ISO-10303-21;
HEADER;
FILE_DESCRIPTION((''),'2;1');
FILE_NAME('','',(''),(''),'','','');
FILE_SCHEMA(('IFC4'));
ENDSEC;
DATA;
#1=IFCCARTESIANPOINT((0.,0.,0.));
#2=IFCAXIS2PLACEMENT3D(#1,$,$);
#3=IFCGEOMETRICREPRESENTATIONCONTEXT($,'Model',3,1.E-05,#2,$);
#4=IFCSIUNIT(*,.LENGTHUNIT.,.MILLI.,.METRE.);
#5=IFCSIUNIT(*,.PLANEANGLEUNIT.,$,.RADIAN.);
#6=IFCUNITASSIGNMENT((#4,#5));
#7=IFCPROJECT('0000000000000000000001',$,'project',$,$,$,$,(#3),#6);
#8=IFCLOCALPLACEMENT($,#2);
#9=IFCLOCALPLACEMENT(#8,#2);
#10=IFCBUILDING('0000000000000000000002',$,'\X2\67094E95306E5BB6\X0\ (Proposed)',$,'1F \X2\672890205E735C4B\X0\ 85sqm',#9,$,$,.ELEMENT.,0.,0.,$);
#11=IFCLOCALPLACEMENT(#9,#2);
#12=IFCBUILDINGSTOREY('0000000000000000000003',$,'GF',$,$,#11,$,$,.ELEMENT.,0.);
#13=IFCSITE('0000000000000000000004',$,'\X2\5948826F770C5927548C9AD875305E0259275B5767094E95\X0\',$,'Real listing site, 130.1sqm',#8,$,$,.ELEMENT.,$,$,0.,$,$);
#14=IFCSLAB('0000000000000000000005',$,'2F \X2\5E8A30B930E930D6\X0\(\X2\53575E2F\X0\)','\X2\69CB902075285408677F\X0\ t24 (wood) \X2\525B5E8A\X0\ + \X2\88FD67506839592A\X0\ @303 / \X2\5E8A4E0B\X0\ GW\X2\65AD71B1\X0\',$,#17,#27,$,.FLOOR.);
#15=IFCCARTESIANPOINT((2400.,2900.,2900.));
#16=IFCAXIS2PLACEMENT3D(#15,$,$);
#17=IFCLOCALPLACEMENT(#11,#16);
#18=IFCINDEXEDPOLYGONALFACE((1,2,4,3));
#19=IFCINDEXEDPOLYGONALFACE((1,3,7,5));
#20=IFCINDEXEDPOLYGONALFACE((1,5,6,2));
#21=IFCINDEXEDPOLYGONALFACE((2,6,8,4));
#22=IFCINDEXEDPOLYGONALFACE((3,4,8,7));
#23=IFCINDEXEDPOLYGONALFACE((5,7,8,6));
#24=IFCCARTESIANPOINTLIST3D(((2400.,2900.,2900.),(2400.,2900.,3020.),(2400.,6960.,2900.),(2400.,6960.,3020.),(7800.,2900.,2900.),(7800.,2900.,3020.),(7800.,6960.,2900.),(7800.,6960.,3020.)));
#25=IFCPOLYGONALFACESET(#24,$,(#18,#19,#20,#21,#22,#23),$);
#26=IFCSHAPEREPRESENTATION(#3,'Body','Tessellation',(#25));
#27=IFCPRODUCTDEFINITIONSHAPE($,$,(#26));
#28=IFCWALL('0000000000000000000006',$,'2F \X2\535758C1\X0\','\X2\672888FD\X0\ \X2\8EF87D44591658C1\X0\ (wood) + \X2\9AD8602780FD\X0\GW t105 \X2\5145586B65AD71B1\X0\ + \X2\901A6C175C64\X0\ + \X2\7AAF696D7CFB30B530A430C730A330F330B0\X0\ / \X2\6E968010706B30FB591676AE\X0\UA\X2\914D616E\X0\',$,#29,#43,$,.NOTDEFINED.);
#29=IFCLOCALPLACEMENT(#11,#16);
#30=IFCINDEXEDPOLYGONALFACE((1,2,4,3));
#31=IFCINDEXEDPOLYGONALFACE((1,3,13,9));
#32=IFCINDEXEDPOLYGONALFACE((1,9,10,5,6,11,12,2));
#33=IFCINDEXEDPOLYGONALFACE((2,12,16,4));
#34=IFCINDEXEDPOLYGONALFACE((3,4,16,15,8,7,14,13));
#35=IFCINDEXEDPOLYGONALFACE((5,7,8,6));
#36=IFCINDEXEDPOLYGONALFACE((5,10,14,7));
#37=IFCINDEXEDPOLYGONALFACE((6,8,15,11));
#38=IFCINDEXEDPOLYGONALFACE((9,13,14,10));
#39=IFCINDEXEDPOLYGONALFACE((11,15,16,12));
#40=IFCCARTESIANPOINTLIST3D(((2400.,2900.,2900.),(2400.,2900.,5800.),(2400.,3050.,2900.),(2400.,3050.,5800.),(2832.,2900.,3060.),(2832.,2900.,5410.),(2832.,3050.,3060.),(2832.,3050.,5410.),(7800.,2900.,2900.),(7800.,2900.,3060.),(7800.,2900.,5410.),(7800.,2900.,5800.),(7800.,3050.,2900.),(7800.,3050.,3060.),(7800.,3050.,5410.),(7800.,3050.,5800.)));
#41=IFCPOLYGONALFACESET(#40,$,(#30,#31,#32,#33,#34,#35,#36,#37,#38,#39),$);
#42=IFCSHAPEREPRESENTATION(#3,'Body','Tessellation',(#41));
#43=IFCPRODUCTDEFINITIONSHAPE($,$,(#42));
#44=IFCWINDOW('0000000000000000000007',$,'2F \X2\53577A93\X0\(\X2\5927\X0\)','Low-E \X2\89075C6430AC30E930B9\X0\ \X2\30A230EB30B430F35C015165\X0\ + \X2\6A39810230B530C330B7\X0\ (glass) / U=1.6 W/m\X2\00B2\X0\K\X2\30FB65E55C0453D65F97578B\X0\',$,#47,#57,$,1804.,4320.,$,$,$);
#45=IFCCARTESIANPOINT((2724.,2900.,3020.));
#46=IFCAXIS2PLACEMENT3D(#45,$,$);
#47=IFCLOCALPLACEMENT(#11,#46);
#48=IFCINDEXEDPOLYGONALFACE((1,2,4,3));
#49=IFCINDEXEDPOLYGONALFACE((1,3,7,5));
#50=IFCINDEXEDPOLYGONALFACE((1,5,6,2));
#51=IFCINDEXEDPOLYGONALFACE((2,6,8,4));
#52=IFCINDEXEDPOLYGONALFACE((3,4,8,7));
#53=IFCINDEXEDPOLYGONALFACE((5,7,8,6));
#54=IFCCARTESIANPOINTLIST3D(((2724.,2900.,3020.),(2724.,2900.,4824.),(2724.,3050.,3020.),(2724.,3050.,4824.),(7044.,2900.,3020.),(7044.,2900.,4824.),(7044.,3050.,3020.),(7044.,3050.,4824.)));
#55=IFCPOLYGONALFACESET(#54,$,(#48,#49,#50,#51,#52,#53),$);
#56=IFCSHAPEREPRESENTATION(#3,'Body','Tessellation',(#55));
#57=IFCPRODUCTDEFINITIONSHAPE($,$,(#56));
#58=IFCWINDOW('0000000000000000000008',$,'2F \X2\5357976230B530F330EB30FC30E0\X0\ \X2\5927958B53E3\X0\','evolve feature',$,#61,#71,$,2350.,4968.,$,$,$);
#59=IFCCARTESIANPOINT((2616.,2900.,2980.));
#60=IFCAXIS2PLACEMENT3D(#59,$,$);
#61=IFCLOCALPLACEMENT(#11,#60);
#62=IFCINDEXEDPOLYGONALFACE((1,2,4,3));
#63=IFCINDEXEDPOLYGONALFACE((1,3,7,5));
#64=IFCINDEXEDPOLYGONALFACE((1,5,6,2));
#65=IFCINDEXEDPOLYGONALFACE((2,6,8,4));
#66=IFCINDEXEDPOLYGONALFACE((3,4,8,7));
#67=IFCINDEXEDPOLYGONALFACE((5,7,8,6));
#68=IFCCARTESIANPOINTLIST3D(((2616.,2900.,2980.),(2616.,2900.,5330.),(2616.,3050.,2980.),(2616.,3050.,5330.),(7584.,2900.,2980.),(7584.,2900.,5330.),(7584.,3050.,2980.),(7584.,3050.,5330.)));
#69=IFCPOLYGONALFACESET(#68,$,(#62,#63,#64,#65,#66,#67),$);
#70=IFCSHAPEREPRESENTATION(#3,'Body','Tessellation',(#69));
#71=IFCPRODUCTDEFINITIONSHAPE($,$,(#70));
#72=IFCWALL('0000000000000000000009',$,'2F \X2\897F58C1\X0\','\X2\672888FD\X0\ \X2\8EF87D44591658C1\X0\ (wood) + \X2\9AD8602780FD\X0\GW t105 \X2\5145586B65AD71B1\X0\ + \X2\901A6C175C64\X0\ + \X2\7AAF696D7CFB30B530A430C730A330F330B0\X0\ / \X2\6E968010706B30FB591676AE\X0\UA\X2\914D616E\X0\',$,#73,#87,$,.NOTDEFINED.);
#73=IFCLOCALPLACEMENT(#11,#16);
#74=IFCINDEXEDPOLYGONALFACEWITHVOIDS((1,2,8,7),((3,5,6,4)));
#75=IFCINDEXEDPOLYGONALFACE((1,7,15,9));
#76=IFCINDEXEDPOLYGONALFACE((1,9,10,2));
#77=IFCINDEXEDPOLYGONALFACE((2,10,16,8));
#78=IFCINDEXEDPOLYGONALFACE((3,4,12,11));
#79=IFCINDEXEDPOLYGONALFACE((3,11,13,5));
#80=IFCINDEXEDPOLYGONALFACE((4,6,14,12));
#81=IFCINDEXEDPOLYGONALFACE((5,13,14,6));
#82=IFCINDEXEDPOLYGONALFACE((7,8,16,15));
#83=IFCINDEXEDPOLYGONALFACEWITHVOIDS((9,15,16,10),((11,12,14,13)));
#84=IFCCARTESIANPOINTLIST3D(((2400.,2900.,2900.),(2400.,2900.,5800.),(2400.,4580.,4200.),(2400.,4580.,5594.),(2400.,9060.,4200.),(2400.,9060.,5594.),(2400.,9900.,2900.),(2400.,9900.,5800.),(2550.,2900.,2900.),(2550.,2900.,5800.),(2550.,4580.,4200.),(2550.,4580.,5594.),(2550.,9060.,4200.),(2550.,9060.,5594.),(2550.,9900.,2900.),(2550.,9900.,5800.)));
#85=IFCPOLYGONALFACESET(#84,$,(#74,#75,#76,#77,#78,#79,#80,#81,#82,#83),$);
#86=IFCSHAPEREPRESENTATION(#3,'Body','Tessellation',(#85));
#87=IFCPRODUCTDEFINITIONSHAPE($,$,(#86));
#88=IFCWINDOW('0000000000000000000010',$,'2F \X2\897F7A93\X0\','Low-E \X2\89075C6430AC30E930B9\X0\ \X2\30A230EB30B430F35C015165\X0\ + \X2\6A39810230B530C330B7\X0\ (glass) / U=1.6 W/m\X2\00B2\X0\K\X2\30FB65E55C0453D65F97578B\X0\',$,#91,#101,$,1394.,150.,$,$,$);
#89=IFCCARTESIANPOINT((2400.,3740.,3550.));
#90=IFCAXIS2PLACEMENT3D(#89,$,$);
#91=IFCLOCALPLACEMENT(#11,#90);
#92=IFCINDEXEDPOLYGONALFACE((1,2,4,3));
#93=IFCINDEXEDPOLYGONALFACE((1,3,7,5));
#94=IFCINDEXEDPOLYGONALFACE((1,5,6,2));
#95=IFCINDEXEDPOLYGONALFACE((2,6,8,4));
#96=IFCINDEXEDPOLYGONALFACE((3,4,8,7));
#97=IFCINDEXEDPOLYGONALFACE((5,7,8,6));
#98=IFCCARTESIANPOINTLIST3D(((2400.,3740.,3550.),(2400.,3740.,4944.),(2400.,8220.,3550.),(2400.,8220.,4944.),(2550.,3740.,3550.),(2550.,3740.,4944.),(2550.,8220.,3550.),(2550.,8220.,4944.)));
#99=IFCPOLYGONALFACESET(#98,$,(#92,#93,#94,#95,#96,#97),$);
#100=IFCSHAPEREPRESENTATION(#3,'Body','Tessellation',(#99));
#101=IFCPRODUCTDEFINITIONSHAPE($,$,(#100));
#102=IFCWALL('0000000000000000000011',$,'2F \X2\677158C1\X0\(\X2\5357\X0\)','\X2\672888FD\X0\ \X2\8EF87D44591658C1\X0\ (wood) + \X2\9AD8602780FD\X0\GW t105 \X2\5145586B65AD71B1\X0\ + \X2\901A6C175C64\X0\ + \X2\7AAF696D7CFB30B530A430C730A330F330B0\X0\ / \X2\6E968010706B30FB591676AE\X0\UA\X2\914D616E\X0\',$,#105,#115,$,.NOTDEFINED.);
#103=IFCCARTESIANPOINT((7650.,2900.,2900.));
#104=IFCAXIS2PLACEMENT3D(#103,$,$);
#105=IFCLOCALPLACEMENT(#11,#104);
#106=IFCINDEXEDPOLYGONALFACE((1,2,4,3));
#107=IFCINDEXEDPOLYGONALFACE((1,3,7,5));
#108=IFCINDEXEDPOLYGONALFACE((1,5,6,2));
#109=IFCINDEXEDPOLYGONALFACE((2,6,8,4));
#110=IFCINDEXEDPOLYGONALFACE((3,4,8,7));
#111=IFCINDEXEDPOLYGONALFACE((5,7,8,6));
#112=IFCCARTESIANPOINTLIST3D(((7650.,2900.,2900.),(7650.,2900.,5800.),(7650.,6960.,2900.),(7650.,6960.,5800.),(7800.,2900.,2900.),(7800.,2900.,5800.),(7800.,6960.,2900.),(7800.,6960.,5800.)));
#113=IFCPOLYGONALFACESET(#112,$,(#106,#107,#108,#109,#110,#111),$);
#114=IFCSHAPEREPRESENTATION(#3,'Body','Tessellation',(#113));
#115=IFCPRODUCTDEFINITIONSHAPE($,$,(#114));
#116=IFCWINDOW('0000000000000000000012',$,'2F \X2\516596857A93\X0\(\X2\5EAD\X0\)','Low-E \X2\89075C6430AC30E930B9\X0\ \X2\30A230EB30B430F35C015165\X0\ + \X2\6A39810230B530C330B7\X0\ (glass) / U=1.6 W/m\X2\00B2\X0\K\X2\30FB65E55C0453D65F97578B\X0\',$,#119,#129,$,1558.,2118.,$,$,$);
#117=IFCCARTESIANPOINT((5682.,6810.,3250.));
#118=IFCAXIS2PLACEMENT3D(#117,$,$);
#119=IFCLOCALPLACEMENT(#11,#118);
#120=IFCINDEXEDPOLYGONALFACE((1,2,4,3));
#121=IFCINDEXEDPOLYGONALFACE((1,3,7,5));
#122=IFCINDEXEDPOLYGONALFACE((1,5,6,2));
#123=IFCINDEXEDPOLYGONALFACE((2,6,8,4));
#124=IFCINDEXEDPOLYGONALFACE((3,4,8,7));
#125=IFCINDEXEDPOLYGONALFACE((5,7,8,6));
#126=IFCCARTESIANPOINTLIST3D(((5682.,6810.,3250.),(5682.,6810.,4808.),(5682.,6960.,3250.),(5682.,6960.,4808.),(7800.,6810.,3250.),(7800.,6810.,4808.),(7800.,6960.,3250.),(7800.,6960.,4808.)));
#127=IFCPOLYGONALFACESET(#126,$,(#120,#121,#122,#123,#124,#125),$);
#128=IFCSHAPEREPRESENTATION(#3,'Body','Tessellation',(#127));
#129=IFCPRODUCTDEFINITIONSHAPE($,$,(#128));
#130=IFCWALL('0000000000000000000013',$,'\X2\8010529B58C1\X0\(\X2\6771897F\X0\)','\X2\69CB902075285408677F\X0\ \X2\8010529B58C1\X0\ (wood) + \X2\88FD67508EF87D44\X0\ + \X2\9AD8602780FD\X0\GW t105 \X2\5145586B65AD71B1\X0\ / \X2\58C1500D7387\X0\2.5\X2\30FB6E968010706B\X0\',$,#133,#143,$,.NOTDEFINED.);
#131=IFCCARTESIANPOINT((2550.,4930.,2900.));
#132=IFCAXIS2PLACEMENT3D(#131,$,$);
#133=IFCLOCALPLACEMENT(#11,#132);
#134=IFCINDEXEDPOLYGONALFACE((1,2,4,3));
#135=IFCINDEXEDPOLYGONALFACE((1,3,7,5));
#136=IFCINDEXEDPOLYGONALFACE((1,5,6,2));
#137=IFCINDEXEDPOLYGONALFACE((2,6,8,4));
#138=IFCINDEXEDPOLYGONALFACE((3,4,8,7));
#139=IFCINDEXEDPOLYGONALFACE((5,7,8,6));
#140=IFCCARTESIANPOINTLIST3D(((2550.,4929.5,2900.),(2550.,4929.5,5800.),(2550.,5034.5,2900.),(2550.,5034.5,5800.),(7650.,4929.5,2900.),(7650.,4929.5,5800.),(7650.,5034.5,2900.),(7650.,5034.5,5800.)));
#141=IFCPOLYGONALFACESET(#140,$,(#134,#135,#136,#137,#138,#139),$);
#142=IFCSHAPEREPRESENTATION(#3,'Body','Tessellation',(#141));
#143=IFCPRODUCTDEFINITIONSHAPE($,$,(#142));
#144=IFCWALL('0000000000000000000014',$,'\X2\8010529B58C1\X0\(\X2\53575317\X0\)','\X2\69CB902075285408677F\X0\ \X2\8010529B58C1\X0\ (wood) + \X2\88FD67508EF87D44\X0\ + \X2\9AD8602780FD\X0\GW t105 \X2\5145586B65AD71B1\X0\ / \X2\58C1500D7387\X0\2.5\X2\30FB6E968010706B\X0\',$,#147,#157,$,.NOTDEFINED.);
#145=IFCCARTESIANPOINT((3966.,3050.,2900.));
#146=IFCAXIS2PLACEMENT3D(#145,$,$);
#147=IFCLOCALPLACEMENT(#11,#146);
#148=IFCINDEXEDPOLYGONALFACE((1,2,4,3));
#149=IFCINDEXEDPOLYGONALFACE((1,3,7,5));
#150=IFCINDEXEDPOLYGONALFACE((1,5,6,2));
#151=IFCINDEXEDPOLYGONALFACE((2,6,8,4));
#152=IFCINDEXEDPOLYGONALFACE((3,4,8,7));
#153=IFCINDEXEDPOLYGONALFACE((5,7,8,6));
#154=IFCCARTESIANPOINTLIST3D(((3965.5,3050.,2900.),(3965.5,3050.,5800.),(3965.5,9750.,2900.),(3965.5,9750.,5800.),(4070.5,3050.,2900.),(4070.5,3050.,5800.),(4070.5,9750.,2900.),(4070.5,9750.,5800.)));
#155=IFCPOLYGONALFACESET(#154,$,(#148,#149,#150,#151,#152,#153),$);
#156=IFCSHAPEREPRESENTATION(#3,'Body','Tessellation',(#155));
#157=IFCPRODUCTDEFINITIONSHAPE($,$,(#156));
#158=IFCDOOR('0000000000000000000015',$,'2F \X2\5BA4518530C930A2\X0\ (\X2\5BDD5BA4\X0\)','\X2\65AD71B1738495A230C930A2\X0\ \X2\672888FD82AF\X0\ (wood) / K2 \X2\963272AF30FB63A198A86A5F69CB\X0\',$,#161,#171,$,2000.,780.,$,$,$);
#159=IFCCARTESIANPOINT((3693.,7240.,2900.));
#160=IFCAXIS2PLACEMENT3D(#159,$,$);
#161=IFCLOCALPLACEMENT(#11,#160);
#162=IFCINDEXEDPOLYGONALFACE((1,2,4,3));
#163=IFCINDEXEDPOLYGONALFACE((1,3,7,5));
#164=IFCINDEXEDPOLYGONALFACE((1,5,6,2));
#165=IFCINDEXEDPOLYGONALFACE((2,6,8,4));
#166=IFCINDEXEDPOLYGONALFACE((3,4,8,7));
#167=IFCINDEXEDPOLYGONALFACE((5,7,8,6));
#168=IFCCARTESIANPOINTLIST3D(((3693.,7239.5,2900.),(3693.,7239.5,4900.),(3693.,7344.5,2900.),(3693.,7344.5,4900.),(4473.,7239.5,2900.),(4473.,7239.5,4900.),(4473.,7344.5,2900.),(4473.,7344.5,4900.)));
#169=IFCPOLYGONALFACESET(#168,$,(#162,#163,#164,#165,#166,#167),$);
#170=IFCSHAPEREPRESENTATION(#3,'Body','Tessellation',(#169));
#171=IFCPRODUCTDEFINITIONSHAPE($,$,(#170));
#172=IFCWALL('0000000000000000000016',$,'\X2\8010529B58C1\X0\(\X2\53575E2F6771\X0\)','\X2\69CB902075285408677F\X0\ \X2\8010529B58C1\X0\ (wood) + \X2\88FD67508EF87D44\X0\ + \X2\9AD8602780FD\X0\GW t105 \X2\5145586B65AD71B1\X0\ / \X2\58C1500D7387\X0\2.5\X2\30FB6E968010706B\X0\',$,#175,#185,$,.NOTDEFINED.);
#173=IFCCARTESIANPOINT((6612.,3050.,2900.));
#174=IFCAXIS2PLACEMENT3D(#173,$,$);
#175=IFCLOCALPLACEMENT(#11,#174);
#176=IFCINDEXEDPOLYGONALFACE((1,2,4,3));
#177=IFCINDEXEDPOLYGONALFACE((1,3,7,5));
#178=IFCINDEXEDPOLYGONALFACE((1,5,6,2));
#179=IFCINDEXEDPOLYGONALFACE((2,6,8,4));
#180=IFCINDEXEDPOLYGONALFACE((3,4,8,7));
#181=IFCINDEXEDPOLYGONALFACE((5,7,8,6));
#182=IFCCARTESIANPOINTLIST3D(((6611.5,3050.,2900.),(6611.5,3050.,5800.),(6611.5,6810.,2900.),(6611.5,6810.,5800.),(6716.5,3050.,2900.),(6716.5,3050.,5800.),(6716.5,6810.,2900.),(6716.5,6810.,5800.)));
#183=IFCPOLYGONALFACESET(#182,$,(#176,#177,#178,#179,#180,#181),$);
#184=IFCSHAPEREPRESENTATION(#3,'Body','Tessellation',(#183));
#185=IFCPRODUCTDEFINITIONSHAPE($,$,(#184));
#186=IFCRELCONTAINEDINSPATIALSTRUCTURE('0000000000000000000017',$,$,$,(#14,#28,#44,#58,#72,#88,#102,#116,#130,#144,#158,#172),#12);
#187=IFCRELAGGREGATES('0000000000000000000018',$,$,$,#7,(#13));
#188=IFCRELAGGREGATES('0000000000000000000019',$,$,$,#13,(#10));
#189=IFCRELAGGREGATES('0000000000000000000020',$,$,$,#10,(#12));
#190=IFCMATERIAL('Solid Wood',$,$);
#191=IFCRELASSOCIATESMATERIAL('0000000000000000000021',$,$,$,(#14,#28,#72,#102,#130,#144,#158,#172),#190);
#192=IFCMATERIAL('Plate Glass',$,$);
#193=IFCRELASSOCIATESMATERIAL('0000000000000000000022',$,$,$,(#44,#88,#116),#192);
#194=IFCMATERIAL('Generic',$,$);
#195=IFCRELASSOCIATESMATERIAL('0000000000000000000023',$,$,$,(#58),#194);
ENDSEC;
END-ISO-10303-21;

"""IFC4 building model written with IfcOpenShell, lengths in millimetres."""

from ifc_helpers import new_model, si_unit, frame, frame_2d, origin, place, context, project, spatial, rectangle, extrude, material, element, fill, save


model = new_model("IFC4")

# Units and contexts
model_context = context("Model", 3, precision=1e-05, world=origin())
ifc_project = project(units=[si_unit("LENGTHUNIT", "METRE", prefix="MILLI"), si_unit("PLANEANGLEUNIT", "RADIAN")], contexts=[model_context])

# Site, building, storey
site_placement = place(None, origin())
site = spatial("IfcSite", under=ifc_project, at=site_placement, Name="奈良県大和高田市大字有井", ObjectType="Real listing site, 130.1sqm", CompositionType="ELEMENT", RefElevation=0.0)
building_placement = place(site_placement, origin())
building = spatial("IfcBuilding", under=site, at=building_placement, Name="有井の家 (Proposed)", ObjectType="1F 木造平屋 85sqm", CompositionType="ELEMENT", ElevationOfRefHeight=0.0, ElevationOfTerrain=0.0)
storey_placement = place(building_placement, origin())
storey = spatial("IfcBuildingStorey", under=building, at=storey_placement, Name="GF", CompositionType="ELEMENT", Elevation=0.0)

# Slab
ifc_material_1 = material(Name="Solid Wood")
slab_placement = place(storey_placement, frame((2400.0, 2900.0, 2900.0)))
element("IfcSlab", 1, at=slab_placement, inside=storey, material=ifc_material_1, Name="2F 床スラブ(南帯)", Description="構造用合板 t24 (wood) 剛床 + 製材根太 @303 / 床下 GW断熱", PredefinedType="FLOOR", context=model_context, shape_type="SweptSolid", body=[
    extrude(rectangle(XDim=5400.0, YDim=4060.0, at=frame_2d((2700.0, 2030.0))), frame((2400.0, 2900.0, 2900.0)), (0.0, 0.0, 1.0), 120.0),
])

# Wall, openings, windows
wall_1_placement = place(storey_placement, frame((2400.0, 2900.0, 2900.0)))
wall_1 = element("IfcWall", 2, at=wall_1_placement, inside=storey, material=ifc_material_1, Name="2F 南壁", Description="木製 軸組外壁 (wood) + 高性能GW t105 充填断熱 + 通気層 + 窯業系サイディング / 準耐火・外皮UA配慮", PredefinedType="NOTDEFINED", context=model_context, shape_type="SweptSolid", body=[
    extrude(rectangle(XDim=5400.0, YDim=150.0, at=frame_2d((2700.0, 75.0))), frame((2400.0, 2900.0, 2900.0)), (0.0, 0.0, 1.0), 2900.0),
])
opening_1_placement = place(storey_placement, frame((2724.0, 2900.0, 3020.0)))
opening_1 = element("IfcOpeningElement", 3, at=opening_1_placement, cuts=wall_1, PredefinedType="NOTDEFINED", context=model_context, shape_type="SweptSolid", body=[
    extrude(rectangle(XDim=4320.0, YDim=150.0, at=frame_2d((2160.0, 75.0))), frame((2724.0, 2900.0, 3020.0)), (0.0, 0.0, 1.0), 1804.0),
])
opening_2_placement = place(storey_placement, frame((2616.0, 2900.0, 2980.0)))
opening_2 = element("IfcOpeningElement", 4, at=opening_2_placement, cuts=wall_1, PredefinedType="NOTDEFINED", context=model_context, shape_type="SweptSolid", body=[
    extrude(rectangle(XDim=4968.0, YDim=150.0, at=frame_2d((2484.0, 75.0))), frame((2616.0, 2900.0, 2980.0)), (0.0, 0.0, 1.0), 2350.0),
])
ifc_material_2 = material(Name="Plate Glass")
window_1_placement = place(storey_placement, frame((2724.0, 2900.0, 3020.0)))
window_1 = element("IfcWindow", 5, at=window_1_placement, inside=storey, material=ifc_material_2, Name="2F 南窓(大)", Description="Low-E 複層ガラス アルゴン封入 + 樹脂サッシ (glass) / U=1.6 W/m²K・日射取得型", OverallHeight=1804.0, OverallWidth=4320.0, context=model_context, shape_type="SweptSolid", body=[
    extrude(rectangle(XDim=4320.0, YDim=150.0, at=frame_2d((2160.0, 75.0))), frame((2724.0, 2900.0, 3020.0)), (0.0, 0.0, 1.0), 1804.0),
])
fill(opening_1, window_1)
ifc_material_3 = material(Name="Generic")
window_2_placement = place(storey_placement, frame((2616.0, 2900.0, 2980.0)))
window_2 = element("IfcWindow", 6, at=window_2_placement, inside=storey, material=ifc_material_3, Name="2F 南面サンルーム 大開口", Description="evolve feature", OverallHeight=2350.0, OverallWidth=4968.0, context=model_context, shape_type="SweptSolid", body=[
    extrude(rectangle(XDim=4968.0, YDim=150.0, at=frame_2d((2484.0, 75.0))), frame((2616.0, 2900.0, 2980.0)), (0.0, 0.0, 1.0), 2350.0),
])
fill(opening_2, window_2)

# Walls, openings, windows
wall_2_placement = place(storey_placement, frame((2400.0, 2900.0, 2900.0)))
wall_2 = element("IfcWall", 7, at=wall_2_placement, inside=storey, material=ifc_material_1, Name="2F 西壁", Description="木製 軸組外壁 (wood) + 高性能GW t105 充填断熱 + 通気層 + 窯業系サイディング / 準耐火・外皮UA配慮", PredefinedType="NOTDEFINED", context=model_context, shape_type="SweptSolid", body=[
    extrude(rectangle(XDim=150.0, YDim=7000.0, at=frame_2d((75.0, 3500.0))), frame((2400.0, 2900.0, 2900.0)), (0.0, 0.0, 1.0), 2900.0),
])
opening_3_placement = place(storey_placement, frame((2400.0, 3740.0, 3550.0)))
opening_3 = element("IfcOpeningElement", 8, at=opening_3_placement, cuts=wall_2, PredefinedType="NOTDEFINED", context=model_context, shape_type="SweptSolid", body=[
    extrude(rectangle(XDim=150.0, YDim=4480.0, at=frame_2d((75.0, 2240.0))), frame((2400.0, 3740.0, 3550.0)), (0.0, 0.0, 1.0), 1394.0),
])
window_3_placement = place(storey_placement, frame((2400.0, 3740.0, 3550.0)))
window_3 = element("IfcWindow", 9, at=window_3_placement, inside=storey, material=ifc_material_2, Name="2F 西窓", Description="Low-E 複層ガラス アルゴン封入 + 樹脂サッシ (glass) / U=1.6 W/m²K・日射取得型", OverallHeight=1394.0, OverallWidth=150.0, context=model_context, shape_type="SweptSolid", body=[
    extrude(rectangle(XDim=150.0, YDim=4480.0, at=frame_2d((75.0, 2240.0))), frame((2400.0, 3740.0, 3550.0)), (0.0, 0.0, 1.0), 1394.0),
])
fill(opening_3, window_3)
wall_3_placement = place(storey_placement, frame((7650.0, 2900.0, 2900.0)))
wall_3 = element("IfcWall", 10, at=wall_3_placement, inside=storey, material=ifc_material_1, Name="2F 東壁(南)", Description="木製 軸組外壁 (wood) + 高性能GW t105 充填断熱 + 通気層 + 窯業系サイディング / 準耐火・外皮UA配慮", PredefinedType="NOTDEFINED", context=model_context, shape_type="SweptSolid", body=[
    extrude(rectangle(XDim=150.0, YDim=4060.0, at=frame_2d((75.0, 2030.0))), frame((7650.0, 2900.0, 2900.0)), (0.0, 0.0, 1.0), 2900.0),
])
opening_4_placement = place(storey_placement, frame((5682.0, 6810.0, 3250.0)))
opening_4 = element("IfcOpeningElement", 11, at=opening_4_placement, cuts=wall_3, PredefinedType="NOTDEFINED", context=model_context, shape_type="SweptSolid", body=[
    extrude(rectangle(XDim=2118.0, YDim=150.0, at=frame_2d((1059.0, 75.0))), frame((5682.0, 6810.0, 3250.0)), (0.0, 0.0, 1.0), 1558.0),
])
window_4_placement = place(storey_placement, frame((5682.0, 6810.0, 3250.0)))
window_4 = element("IfcWindow", 12, at=window_4_placement, inside=storey, material=ifc_material_2, Name="2F 入隅窓(庭)", Description="Low-E 複層ガラス アルゴン封入 + 樹脂サッシ (glass) / U=1.6 W/m²K・日射取得型", OverallHeight=1558.0, OverallWidth=2118.0, context=model_context, shape_type="SweptSolid", body=[
    extrude(rectangle(XDim=2118.0, YDim=150.0, at=frame_2d((1059.0, 75.0))), frame((5682.0, 6810.0, 3250.0)), (0.0, 0.0, 1.0), 1558.0),
])
fill(opening_4, window_4)

# Wall
wall_4_placement = place(storey_placement, frame((2550.0, 4930.0, 2900.0)))
element("IfcWall", 13, at=wall_4_placement, inside=storey, material=ifc_material_1, Name="耐力壁(東西)", Description="構造用合板 耐力壁 (wood) + 製材軸組 + 高性能GW t105 充填断熱 / 壁倍率2.5・準耐火", PredefinedType="NOTDEFINED", context=model_context, shape_type="SweptSolid", body=[
    extrude(rectangle(XDim=5100.0, YDim=105.0, at=frame_2d((2550.0, 52.0))), frame((2550.0, 4930.0, 2900.0)), (0.0, 0.0, 1.0), 2900.0),
])

# Wall, opening, door
wall_5_placement = place(storey_placement, frame((3966.0, 3050.0, 2900.0)))
wall_5 = element("IfcWall", 14, at=wall_5_placement, inside=storey, material=ifc_material_1, Name="耐力壁(南北)", Description="構造用合板 耐力壁 (wood) + 製材軸組 + 高性能GW t105 充填断熱 / 壁倍率2.5・準耐火", PredefinedType="NOTDEFINED", context=model_context, shape_type="SweptSolid", body=[
    extrude(rectangle(XDim=105.0, YDim=6700.0, at=frame_2d((52.0, 3350.0))), frame((3966.0, 3050.0, 2900.0)), (0.0, 0.0, 1.0), 2900.0),
])
opening_5_placement = place(storey_placement, frame((3693.0, 7240.0, 2900.0)))
opening_5 = element("IfcOpeningElement", 15, at=opening_5_placement, cuts=wall_5, PredefinedType="NOTDEFINED", context=model_context, shape_type="SweptSolid", body=[
    extrude(rectangle(XDim=780.0, YDim=105.0, at=frame_2d((390.0, 52.0))), frame((3693.0, 7240.0, 2900.0)), (0.0, 0.0, 1.0), 2000.0),
])
door_placement = place(storey_placement, frame((3693.0, 7240.0, 2900.0)))
door = element("IfcDoor", 16, at=door_placement, inside=storey, material=ifc_material_1, Name="2F 室内ドア (寝室)", Description="断熱玄関ドア 木製芯 (wood) / K2 防犯・採風機構", OverallHeight=2000.0, OverallWidth=780.0, context=model_context, shape_type="SweptSolid", body=[
    extrude(rectangle(XDim=780.0, YDim=105.0, at=frame_2d((390.0, 52.0))), frame((3693.0, 7240.0, 2900.0)), (0.0, 0.0, 1.0), 2000.0),
])
fill(opening_5, door)

# Wall
wall_6_placement = place(storey_placement, frame((6612.0, 3050.0, 2900.0)))
element("IfcWall", 17, at=wall_6_placement, inside=storey, material=ifc_material_1, Name="耐力壁(南帯東)", Description="構造用合板 耐力壁 (wood) + 製材軸組 + 高性能GW t105 充填断熱 / 壁倍率2.5・準耐火", PredefinedType="NOTDEFINED", context=model_context, shape_type="SweptSolid", body=[
    extrude(rectangle(XDim=105.0, YDim=3760.0, at=frame_2d((52.0, 1880.0))), frame((6612.0, 3050.0, 2900.0)), (0.0, 0.0, 1.0), 2900.0),
])

save(model, "model.ifc")
